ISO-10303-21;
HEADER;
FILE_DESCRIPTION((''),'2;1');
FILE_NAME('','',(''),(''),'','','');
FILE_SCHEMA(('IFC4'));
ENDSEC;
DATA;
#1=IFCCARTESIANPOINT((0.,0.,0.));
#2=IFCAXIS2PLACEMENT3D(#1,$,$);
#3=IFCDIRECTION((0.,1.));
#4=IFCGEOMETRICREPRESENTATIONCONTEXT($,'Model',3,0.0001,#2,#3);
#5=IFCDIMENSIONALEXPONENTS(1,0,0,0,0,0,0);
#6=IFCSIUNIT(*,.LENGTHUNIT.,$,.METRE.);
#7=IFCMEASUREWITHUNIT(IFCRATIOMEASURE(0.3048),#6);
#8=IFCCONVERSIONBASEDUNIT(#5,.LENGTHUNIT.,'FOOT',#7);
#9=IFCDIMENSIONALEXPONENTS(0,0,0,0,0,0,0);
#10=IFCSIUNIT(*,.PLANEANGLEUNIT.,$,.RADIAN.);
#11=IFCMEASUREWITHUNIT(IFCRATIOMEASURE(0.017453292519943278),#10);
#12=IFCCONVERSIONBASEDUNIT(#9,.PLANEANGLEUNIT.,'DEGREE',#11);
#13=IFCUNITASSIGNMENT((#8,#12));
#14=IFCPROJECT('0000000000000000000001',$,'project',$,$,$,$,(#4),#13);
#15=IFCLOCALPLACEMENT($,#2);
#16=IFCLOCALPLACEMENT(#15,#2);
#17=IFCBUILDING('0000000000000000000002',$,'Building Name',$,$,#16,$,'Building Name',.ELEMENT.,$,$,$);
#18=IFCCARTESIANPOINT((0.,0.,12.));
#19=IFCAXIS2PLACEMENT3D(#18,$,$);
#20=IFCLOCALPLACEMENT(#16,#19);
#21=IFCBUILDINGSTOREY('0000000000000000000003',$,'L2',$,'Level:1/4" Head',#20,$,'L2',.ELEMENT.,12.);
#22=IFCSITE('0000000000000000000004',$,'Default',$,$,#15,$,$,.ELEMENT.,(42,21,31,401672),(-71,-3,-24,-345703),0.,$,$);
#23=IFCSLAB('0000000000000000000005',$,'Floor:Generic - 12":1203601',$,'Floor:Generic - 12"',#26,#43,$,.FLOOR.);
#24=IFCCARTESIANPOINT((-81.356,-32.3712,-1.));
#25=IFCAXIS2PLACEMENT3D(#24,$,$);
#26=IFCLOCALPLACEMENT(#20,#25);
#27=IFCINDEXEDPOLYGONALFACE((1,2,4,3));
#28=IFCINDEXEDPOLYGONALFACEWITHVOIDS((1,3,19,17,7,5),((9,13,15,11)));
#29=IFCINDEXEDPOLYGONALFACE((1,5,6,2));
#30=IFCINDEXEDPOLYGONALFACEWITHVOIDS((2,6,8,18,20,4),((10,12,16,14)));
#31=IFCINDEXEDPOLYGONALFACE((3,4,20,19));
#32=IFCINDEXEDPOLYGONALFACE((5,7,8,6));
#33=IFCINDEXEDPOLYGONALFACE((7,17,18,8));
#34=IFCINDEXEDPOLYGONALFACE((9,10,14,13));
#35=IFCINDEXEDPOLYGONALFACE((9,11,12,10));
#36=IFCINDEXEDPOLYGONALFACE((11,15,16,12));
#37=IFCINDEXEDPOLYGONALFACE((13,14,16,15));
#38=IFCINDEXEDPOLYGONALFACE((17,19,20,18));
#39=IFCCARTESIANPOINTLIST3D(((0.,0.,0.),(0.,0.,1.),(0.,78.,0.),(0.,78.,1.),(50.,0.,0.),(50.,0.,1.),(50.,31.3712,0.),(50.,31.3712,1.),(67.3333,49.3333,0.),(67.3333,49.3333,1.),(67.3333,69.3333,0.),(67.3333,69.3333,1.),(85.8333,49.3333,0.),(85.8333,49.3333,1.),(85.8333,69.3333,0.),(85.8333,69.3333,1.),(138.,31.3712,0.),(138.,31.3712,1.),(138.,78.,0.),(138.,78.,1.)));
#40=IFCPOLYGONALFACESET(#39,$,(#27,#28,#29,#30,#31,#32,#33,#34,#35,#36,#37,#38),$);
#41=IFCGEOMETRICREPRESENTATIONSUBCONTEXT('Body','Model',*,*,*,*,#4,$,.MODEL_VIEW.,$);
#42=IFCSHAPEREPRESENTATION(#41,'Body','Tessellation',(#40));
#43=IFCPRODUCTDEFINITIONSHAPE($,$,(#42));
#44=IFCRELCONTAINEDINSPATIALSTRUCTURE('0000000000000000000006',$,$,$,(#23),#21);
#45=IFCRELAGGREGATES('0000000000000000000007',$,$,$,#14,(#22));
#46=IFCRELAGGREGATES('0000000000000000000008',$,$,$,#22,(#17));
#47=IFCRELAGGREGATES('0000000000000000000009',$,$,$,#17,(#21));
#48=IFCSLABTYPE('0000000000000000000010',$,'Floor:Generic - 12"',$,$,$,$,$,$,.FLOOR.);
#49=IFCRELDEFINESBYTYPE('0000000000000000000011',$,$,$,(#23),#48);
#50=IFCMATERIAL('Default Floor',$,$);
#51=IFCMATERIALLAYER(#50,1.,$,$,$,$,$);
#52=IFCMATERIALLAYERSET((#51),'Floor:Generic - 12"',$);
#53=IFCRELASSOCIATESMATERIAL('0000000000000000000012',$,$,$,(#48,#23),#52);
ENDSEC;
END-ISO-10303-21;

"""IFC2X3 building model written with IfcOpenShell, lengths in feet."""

from ifc_helpers import new_model, entity, si_unit, converted_unit, direction, frame, frame_2d, origin, place, context, subcontext, project, spatial, polyline, rectangle, outline, extrude, material, layer, layer_set, layer_usage, type_object, element, save


model = new_model("IFC2X3")

# Units and contexts
model_context = context("Model", 3, precision=0.0001, world=origin(), true_north=direction((0.0, 1.0)))
body_context = subcontext(model_context, "Body", "Model", "MODEL_VIEW")
ifc_project = project(units=[converted_unit("LENGTHUNIT", "FOOT", entity("IfcRatioMeasure", 0.3048), si_unit("LENGTHUNIT", "METRE"), dimensions=[1, 0, 0, 0, 0, 0, 0]), converted_unit("PLANEANGLEUNIT", "DEGREE", entity("IfcRatioMeasure", 0.017453292519943278), si_unit("PLANEANGLEUNIT", "RADIAN"), dimensions=[0, 0, 0, 0, 0, 0, 0])], contexts=[model_context])

# Site, building, storey
site_placement = place(None, origin())
site = spatial("IfcSite", under=ifc_project, at=site_placement, Name="Default", CompositionType="ELEMENT", RefLatitude=(42, 21, 31, 401672), RefLongitude=(-71, -3, -24, -345703), RefElevation=0.0)
building_placement = place(site_placement, origin())
building = spatial("IfcBuilding", under=site, at=building_placement, Name="Building Name", LongName="Building Name", CompositionType="ELEMENT")
storey_placement = place(building_placement, frame((0.0, 0.0, 12.0)))
storey = spatial("IfcBuildingStorey", under=building, at=storey_placement, Name="L2", ObjectType="Level:1/4\" Head", LongName="L2", CompositionType="ELEMENT", Elevation=12.0)

# Slab, opening
ifc_material_1 = material(Name="Default Floor")
ifc_layer_1 = layer(ifc_material_1, 1.0)
ifc_layer_set_1 = layer_set([ifc_layer_1], Name="Floor:Generic - 12\"")
ifc_layer_usage_1 = layer_usage(ifc_layer_set_1, "AXIS3", "POSITIVE", 0.0)
slab_type_1 = type_object("IfcSlabType", Name="Floor:Generic - 12\"", PredefinedType="FLOOR", material=ifc_layer_set_1)
slab_1_placement = place(storey_placement, frame((-81.356, -32.3712, -1.0)))
slab_1 = element("IfcSlab", 1, at=slab_1_placement, inside=storey, type_object=slab_type_1, material=ifc_layer_usage_1, Name="Floor:Generic - 12\":1203601", ObjectType="Floor:Generic - 12\"", PredefinedType="FLOOR", context=body_context, shape_type="SweptSolid", body=[
    extrude(outline(polyline([(69.0, -39.0), (69.0, 39.0), (-69.0, 39.0), (-69.0, -7.6288), (19.0, -7.6288), (19.0, -39.0), (69.0, -39.0)])), frame((69.0, 39.0, 1.0), z_axis=(0.0, 0.0, -1.0), x_axis=(-1.0, 0.0, 0.0)), (0.0, 0.0, 1.0), 1.0),
])
opening_placement = place(slab_1_placement, origin())
element("IfcOpeningElement", 2, at=opening_placement, cuts=slab_1, ObjectType="Opening", context=body_context, shape_type="SweptSolid", body=[
    extrude(rectangle(XDim=20.0, YDim=18.5, at=frame_2d((0.0, 0.0), x_axis=(1.0, 0.0))), frame((76.5833, 59.3333, 1.0), z_axis=(0.0, 0.0, -1.0), x_axis=(0.0, -1.0, 0.0)), (0.0, 0.0, 1.0), 1.0),
])

save(model, "model.ifc")
